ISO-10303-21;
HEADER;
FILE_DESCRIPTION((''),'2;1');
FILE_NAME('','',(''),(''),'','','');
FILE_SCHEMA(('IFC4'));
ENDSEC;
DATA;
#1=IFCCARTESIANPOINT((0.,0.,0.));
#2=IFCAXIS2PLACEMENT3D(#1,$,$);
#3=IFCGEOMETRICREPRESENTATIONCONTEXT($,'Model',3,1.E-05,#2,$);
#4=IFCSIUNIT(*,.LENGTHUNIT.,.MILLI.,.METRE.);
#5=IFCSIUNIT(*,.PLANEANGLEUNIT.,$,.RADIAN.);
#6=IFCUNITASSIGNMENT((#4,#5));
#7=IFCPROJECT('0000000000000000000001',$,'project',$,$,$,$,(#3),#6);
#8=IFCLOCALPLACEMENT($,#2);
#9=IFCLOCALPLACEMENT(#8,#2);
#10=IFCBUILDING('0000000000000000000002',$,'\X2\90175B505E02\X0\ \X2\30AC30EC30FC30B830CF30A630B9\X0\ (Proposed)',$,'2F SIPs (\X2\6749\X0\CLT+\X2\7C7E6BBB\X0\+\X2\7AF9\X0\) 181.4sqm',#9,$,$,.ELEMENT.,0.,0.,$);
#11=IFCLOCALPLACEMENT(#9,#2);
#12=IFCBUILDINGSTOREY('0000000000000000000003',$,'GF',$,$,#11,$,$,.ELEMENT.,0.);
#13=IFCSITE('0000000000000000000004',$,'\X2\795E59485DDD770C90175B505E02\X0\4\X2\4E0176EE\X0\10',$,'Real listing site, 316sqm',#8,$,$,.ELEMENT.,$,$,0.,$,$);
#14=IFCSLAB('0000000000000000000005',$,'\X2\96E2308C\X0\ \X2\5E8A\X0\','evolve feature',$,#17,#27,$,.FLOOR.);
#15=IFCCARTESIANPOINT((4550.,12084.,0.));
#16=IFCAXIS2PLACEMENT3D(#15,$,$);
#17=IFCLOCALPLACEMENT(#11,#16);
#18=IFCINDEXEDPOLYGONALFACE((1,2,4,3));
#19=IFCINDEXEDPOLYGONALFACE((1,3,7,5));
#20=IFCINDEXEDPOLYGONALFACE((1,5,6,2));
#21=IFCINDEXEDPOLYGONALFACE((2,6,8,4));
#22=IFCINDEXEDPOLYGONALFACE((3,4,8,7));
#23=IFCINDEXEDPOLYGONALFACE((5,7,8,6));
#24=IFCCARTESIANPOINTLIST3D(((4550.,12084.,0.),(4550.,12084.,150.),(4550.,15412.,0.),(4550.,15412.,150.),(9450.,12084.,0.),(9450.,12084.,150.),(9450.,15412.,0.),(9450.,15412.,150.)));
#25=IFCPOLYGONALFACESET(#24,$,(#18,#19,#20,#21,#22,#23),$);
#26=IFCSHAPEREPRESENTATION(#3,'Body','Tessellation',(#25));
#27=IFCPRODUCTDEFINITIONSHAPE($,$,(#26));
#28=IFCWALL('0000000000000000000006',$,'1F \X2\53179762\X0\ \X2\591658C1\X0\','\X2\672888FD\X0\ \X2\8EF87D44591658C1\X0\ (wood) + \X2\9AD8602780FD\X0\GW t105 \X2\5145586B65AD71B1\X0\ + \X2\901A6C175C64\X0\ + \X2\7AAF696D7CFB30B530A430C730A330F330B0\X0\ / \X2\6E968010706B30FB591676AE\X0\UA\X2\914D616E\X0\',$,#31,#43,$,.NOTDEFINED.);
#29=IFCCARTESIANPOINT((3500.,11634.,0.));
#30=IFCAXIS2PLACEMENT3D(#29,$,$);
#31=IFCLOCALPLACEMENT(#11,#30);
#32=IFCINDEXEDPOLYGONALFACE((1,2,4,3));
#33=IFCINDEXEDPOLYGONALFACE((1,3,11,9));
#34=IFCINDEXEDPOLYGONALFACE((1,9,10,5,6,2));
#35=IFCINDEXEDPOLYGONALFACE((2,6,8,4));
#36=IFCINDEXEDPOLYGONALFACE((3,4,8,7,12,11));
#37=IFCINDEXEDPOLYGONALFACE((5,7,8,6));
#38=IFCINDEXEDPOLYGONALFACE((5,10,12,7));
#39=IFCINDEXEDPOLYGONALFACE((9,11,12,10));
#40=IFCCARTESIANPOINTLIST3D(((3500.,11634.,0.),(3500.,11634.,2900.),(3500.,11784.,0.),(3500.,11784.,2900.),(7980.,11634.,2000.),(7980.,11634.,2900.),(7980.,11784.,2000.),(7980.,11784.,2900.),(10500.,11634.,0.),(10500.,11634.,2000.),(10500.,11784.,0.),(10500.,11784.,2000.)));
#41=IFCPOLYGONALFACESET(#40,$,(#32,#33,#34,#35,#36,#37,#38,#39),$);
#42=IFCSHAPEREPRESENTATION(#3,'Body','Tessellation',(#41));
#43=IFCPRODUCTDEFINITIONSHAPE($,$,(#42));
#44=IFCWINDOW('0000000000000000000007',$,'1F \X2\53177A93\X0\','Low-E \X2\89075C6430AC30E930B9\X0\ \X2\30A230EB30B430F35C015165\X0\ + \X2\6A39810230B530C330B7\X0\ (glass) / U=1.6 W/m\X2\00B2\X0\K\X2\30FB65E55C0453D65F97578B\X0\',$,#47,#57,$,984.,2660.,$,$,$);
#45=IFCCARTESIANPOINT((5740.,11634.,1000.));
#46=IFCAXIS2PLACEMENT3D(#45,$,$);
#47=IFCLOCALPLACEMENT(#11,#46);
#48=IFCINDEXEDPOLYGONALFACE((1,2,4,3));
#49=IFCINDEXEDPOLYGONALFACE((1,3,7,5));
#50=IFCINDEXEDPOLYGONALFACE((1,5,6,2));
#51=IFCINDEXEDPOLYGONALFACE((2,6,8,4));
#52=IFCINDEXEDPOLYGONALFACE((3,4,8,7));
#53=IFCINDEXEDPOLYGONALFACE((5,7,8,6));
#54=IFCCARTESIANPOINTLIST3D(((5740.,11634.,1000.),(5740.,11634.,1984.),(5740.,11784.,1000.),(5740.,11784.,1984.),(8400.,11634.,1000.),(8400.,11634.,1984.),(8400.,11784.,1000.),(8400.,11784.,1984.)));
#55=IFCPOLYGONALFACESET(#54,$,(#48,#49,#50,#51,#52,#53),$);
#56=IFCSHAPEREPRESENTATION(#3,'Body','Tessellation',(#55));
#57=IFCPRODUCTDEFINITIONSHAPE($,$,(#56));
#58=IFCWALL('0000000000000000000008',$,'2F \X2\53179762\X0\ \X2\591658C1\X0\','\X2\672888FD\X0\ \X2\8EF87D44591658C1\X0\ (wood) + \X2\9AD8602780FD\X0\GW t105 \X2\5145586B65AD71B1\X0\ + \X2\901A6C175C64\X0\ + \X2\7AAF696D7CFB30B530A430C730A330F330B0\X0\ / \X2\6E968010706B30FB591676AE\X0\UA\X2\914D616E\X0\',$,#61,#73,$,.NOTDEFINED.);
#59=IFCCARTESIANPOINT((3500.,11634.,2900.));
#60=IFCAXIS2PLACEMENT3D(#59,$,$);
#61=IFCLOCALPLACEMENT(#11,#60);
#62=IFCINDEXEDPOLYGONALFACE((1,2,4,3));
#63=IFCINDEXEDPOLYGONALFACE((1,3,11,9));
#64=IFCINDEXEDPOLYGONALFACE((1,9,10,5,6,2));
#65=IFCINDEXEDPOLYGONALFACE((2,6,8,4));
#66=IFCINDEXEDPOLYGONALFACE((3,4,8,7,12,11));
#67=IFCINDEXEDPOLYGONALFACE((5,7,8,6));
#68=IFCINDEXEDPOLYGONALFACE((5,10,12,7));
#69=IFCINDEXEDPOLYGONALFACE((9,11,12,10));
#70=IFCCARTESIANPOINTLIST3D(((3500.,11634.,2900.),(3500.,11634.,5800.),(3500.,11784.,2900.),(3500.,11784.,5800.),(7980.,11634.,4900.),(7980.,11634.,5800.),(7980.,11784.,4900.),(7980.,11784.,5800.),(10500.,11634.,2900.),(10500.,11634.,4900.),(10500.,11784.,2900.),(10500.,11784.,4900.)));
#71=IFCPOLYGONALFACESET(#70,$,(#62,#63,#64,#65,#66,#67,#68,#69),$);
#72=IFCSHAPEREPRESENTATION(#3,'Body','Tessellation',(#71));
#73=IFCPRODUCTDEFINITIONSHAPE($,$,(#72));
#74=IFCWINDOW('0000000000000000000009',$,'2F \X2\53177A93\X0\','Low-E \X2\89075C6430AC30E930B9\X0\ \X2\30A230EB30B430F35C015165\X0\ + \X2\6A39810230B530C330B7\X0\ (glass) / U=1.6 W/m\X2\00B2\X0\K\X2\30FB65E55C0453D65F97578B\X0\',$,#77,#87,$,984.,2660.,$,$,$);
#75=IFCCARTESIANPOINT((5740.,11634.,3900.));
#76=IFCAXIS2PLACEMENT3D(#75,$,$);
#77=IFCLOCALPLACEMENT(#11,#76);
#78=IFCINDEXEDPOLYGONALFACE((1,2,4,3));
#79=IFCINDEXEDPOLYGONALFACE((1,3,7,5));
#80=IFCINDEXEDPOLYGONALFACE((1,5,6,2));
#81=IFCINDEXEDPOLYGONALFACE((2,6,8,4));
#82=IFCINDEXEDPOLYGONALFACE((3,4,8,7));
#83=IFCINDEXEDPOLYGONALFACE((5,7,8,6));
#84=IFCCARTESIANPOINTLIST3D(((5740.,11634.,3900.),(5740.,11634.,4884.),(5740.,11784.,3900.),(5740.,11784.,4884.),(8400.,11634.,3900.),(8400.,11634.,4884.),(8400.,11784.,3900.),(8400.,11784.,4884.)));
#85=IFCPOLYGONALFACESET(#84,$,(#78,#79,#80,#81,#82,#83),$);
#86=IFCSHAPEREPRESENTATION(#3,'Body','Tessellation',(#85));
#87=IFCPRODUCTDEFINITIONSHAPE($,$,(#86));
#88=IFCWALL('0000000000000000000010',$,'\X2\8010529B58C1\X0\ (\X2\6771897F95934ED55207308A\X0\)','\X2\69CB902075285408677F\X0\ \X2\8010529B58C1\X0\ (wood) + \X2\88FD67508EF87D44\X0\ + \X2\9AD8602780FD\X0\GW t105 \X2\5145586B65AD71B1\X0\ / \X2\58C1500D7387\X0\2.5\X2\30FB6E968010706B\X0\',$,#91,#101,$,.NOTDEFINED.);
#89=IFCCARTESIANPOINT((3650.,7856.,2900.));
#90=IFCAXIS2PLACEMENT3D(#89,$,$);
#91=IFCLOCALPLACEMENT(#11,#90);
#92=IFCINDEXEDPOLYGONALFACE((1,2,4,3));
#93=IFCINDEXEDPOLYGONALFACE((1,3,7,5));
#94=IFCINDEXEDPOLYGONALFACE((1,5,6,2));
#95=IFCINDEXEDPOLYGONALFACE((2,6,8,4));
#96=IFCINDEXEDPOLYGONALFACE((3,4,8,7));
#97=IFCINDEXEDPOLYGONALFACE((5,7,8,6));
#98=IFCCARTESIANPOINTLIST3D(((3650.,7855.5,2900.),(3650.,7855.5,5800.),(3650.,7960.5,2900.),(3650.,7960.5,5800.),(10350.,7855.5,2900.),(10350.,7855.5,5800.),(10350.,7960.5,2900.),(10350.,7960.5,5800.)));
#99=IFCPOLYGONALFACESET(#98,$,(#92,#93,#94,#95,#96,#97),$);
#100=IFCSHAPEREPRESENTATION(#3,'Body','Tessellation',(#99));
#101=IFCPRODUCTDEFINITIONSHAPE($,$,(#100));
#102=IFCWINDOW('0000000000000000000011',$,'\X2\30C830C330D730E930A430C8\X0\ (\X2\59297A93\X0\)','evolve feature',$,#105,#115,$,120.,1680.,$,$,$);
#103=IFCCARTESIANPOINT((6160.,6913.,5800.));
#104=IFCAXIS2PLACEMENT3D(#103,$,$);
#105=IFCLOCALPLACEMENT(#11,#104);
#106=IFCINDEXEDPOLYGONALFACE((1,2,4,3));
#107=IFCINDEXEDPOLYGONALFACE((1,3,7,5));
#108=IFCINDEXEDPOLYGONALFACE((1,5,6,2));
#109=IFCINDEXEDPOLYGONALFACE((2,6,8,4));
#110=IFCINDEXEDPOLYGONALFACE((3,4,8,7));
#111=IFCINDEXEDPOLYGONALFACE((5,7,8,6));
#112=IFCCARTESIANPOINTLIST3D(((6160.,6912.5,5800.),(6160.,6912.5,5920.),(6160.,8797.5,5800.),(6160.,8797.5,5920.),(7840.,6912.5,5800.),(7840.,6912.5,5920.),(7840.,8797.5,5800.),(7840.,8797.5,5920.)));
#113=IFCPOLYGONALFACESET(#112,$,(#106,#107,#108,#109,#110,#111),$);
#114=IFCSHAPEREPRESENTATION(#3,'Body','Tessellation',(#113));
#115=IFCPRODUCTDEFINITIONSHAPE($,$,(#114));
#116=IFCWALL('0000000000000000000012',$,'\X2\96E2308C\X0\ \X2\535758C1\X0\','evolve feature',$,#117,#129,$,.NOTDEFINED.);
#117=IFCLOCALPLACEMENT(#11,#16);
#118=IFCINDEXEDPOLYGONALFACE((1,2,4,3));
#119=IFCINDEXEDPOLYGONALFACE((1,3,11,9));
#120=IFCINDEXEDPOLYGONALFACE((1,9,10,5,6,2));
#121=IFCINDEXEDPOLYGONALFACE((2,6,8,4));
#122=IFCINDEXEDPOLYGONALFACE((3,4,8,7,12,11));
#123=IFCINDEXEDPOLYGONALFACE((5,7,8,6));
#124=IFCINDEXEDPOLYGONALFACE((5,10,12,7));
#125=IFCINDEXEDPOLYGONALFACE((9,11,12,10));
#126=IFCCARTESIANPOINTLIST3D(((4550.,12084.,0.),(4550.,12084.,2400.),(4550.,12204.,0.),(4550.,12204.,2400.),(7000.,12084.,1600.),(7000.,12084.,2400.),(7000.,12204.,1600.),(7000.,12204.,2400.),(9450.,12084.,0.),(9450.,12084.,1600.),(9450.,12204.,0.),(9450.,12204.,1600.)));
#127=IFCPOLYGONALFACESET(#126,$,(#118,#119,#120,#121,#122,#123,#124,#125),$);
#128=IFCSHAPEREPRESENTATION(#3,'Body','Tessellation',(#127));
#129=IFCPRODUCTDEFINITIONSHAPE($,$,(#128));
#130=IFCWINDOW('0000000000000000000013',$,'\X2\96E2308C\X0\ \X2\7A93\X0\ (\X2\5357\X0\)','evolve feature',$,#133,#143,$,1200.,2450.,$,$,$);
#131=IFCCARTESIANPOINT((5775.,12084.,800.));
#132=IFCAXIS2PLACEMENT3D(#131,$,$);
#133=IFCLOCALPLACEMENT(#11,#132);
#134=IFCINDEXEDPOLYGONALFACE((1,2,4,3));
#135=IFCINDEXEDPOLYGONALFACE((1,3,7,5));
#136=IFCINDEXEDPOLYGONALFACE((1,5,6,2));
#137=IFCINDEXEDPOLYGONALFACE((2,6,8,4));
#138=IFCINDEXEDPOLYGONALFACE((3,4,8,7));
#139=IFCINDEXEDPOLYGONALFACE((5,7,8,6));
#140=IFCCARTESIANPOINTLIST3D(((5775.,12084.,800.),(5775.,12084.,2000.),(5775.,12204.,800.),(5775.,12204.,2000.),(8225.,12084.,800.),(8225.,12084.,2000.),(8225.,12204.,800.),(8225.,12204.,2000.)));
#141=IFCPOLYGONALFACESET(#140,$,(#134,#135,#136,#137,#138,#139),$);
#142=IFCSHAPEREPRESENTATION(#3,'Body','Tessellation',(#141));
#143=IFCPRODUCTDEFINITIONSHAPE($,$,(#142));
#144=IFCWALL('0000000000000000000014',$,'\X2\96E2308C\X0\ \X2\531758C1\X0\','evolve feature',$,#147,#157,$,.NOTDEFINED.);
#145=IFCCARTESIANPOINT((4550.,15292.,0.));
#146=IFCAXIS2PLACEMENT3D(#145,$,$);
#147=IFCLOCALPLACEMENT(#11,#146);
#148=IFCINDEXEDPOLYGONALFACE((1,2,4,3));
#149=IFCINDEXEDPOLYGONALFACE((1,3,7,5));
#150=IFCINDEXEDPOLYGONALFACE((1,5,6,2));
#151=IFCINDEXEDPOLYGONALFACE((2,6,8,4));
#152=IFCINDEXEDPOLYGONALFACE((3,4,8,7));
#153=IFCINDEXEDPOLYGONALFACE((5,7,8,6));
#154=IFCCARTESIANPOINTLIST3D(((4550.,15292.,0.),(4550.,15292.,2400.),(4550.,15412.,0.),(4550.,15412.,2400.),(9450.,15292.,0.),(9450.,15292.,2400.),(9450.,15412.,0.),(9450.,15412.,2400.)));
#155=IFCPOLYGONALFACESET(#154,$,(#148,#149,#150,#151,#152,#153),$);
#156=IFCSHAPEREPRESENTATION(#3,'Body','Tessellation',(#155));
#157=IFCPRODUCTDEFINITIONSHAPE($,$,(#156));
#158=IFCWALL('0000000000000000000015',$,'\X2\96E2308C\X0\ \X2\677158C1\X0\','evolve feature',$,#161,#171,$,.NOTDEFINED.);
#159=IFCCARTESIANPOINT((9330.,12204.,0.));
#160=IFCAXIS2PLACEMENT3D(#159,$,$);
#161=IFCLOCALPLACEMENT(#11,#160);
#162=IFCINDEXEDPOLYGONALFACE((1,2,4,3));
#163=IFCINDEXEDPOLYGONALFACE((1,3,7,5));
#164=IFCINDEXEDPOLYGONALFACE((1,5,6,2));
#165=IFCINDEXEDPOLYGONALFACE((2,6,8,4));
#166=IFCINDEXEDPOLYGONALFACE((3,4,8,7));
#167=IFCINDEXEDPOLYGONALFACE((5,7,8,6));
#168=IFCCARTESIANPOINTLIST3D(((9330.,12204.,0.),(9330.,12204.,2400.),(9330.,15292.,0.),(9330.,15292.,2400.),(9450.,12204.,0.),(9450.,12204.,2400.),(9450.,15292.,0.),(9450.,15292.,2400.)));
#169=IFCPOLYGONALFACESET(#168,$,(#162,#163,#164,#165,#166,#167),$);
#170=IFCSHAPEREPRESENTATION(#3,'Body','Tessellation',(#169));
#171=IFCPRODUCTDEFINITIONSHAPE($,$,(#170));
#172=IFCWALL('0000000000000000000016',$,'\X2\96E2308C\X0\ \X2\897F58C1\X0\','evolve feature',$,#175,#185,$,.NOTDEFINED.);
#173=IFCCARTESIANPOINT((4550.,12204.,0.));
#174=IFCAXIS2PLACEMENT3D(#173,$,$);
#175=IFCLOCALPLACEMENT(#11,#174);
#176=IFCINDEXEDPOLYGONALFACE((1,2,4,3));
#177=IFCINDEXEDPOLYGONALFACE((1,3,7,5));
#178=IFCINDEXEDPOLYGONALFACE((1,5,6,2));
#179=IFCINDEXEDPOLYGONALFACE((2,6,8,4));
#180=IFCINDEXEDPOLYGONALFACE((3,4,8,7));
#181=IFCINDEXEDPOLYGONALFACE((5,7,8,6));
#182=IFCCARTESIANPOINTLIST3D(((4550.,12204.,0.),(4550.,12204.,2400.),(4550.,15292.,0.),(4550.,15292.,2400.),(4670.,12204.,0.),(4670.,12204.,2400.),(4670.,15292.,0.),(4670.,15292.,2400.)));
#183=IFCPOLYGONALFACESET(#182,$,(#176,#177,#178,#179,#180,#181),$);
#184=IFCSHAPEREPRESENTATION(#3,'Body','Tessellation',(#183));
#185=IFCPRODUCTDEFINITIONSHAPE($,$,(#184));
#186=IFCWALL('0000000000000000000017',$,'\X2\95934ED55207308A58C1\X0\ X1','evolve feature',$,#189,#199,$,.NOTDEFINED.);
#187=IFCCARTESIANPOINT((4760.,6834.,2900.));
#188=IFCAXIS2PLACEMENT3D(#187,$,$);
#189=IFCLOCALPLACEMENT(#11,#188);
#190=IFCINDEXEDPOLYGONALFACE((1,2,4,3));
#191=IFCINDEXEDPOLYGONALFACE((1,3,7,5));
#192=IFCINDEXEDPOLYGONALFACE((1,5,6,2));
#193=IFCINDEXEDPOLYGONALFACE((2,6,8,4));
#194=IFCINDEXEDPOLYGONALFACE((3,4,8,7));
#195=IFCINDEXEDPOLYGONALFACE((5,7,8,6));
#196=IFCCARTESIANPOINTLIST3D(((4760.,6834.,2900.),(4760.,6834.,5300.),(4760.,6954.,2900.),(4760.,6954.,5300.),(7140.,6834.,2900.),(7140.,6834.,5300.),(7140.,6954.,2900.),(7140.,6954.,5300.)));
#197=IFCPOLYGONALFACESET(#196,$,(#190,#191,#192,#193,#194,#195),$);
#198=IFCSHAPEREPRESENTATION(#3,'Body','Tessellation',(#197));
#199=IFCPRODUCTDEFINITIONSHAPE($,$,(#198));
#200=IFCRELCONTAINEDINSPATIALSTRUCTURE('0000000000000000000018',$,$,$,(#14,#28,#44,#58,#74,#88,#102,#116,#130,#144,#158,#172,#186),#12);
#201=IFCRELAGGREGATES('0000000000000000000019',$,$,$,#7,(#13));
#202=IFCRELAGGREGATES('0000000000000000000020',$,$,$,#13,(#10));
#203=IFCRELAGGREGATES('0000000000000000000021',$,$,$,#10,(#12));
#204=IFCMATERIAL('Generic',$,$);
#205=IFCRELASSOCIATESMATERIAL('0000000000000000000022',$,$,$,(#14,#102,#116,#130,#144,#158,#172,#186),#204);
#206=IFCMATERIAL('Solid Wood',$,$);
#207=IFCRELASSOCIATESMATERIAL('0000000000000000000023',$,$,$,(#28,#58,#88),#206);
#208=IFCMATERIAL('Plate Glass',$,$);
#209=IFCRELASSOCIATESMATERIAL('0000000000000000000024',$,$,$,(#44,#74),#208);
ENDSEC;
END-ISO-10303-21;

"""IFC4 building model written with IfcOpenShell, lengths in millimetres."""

from ifc_helpers import new_model, si_unit, frame, frame_2d, origin, place, context, project, spatial, rectangle, extrude, material, element, fill, save


model = new_model("IFC4")

# Units and contexts
model_context = context("Model", 3, precision=1e-05, world=origin())
ifc_project = project(units=[si_unit("LENGTHUNIT", "METRE", prefix="MILLI"), si_unit("PLANEANGLEUNIT", "RADIAN")], contexts=[model_context])

# Site, building, storey
site_placement = place(None, origin())
site = spatial("IfcSite", under=ifc_project, at=site_placement, Name="神奈川県逗子市4丁目10", ObjectType="Real listing site, 316sqm", CompositionType="ELEMENT", RefElevation=0.0)
building_placement = place(site_placement, origin())
building = spatial("IfcBuilding", under=site, at=building_placement, Name="逗子市 ガレージハウス (Proposed)", ObjectType="2F SIPs (杉CLT+籾殻+竹) 181.4sqm", CompositionType="ELEMENT", ElevationOfRefHeight=0.0, ElevationOfTerrain=0.0)
storey_placement = place(building_placement, origin())
storey = spatial("IfcBuildingStorey", under=building, at=storey_placement, Name="GF", CompositionType="ELEMENT", Elevation=0.0)

# Slab
ifc_material_1 = material(Name="Generic")
slab_placement = place(storey_placement, frame((4550.0, 12084.0, 0.0)))
element("IfcSlab", 1, at=slab_placement, inside=storey, material=ifc_material_1, Name="離れ 床", Description="evolve feature", PredefinedType="FLOOR", context=model_context, shape_type="SweptSolid", body=[
    extrude(rectangle(XDim=4900.0, YDim=3328.0, at=frame_2d((2450.0, 1664.0))), frame((4550.0, 12084.0, 0.0)), (0.0, 0.0, 1.0), 150.0),
])

# Wall, opening, window
ifc_material_2 = material(Name="Solid Wood")
wall_1_placement = place(storey_placement, frame((3500.0, 11634.0, 0.0)))
wall_1 = element("IfcWall", 2, at=wall_1_placement, inside=storey, material=ifc_material_2, Name="1F 北面 外壁", Description="木製 軸組外壁 (wood) + 高性能GW t105 充填断熱 + 通気層 + 窯業系サイディング / 準耐火・外皮UA配慮", PredefinedType="NOTDEFINED", context=model_context, shape_type="SweptSolid", body=[
    extrude(rectangle(XDim=7000.0, YDim=150.0, at=frame_2d((3500.0, 75.0))), frame((3500.0, 11634.0, 0.0)), (0.0, 0.0, 1.0), 2900.0),
])
opening_1_placement = place(storey_placement, frame((5740.0, 11634.0, 1000.0)))
opening_1 = element("IfcOpeningElement", 3, at=opening_1_placement, cuts=wall_1, PredefinedType="NOTDEFINED", context=model_context, shape_type="SweptSolid", body=[
    extrude(rectangle(XDim=2660.0, YDim=150.0, at=frame_2d((1330.0, 75.0))), frame((5740.0, 11634.0, 1000.0)), (0.0, 0.0, 1.0), 984.0),
])
ifc_material_3 = material(Name="Plate Glass")
window_1_placement = place(storey_placement, frame((5740.0, 11634.0, 1000.0)))
window_1 = element("IfcWindow", 4, at=window_1_placement, inside=storey, material=ifc_material_3, Name="1F 北窓", Description="Low-E 複層ガラス アルゴン封入 + 樹脂サッシ (glass) / U=1.6 W/m²K・日射取得型", OverallHeight=984.0, OverallWidth=2660.0, context=model_context, shape_type="SweptSolid", body=[
    extrude(rectangle(XDim=2660.0, YDim=150.0, at=frame_2d((1330.0, 75.0))), frame((5740.0, 11634.0, 1000.0)), (0.0, 0.0, 1.0), 984.0),
])
fill(opening_1, window_1)

# Wall, opening, window
wall_2_placement = place(storey_placement, frame((3500.0, 11634.0, 2900.0)))
wall_2 = element("IfcWall", 5, at=wall_2_placement, inside=storey, material=ifc_material_2, Name="2F 北面 外壁", Description="木製 軸組外壁 (wood) + 高性能GW t105 充填断熱 + 通気層 + 窯業系サイディング / 準耐火・外皮UA配慮", PredefinedType="NOTDEFINED", context=model_context, shape_type="SweptSolid", body=[
    extrude(rectangle(XDim=7000.0, YDim=150.0, at=frame_2d((3500.0, 75.0))), frame((3500.0, 11634.0, 2900.0)), (0.0, 0.0, 1.0), 2900.0),
])
opening_2_placement = place(storey_placement, frame((5740.0, 11634.0, 3900.0)))
opening_2 = element("IfcOpeningElement", 6, at=opening_2_placement, cuts=wall_2, PredefinedType="NOTDEFINED", context=model_context, shape_type="SweptSolid", body=[
    extrude(rectangle(XDim=2660.0, YDim=150.0, at=frame_2d((1330.0, 75.0))), frame((5740.0, 11634.0, 3900.0)), (0.0, 0.0, 1.0), 984.0),
])
window_2_placement = place(storey_placement, frame((5740.0, 11634.0, 3900.0)))
window_2 = element("IfcWindow", 7, at=window_2_placement, inside=storey, material=ifc_material_3, Name="2F 北窓", Description="Low-E 複層ガラス アルゴン封入 + 樹脂サッシ (glass) / U=1.6 W/m²K・日射取得型", OverallHeight=984.0, OverallWidth=2660.0, context=model_context, shape_type="SweptSolid", body=[
    extrude(rectangle(XDim=2660.0, YDim=150.0, at=frame_2d((1330.0, 75.0))), frame((5740.0, 11634.0, 3900.0)), (0.0, 0.0, 1.0), 984.0),
])
fill(opening_2, window_2)

# Wall
wall_3_placement = place(storey_placement, frame((3650.0, 7856.0, 2900.0)))
element("IfcWall", 8, at=wall_3_placement, inside=storey, material=ifc_material_2, Name="耐力壁 (東西間仕切り)", Description="構造用合板 耐力壁 (wood) + 製材軸組 + 高性能GW t105 充填断熱 / 壁倍率2.5・準耐火", PredefinedType="NOTDEFINED", context=model_context, shape_type="SweptSolid", body=[
    extrude(rectangle(XDim=6700.0, YDim=105.0, at=frame_2d((3350.0, 52.0))), frame((3650.0, 7856.0, 2900.0)), (0.0, 0.0, 1.0), 2900.0),
])

# Window
window_3_placement = place(storey_placement, frame((6160.0, 6913.0, 5800.0)))
element("IfcWindow", 9, at=window_3_placement, inside=storey, material=ifc_material_1, Name="トップライト (天窓)", Description="evolve feature", OverallHeight=120.0, OverallWidth=1680.0, context=model_context, shape_type="SweptSolid", body=[
    extrude(rectangle(XDim=1680.0, YDim=1885.0, at=frame_2d((840.0, 942.0))), frame((6160.0, 6913.0, 5800.0)), (0.0, 0.0, 1.0), 120.0),
])

# Wall, opening, window
wall_4_placement = place(storey_placement, frame((4550.0, 12084.0, 0.0)))
wall_4 = element("IfcWall", 10, at=wall_4_placement, inside=storey, material=ifc_material_1, Name="離れ 南壁", Description="evolve feature", PredefinedType="NOTDEFINED", context=model_context, shape_type="SweptSolid", body=[
    extrude(rectangle(XDim=4900.0, YDim=120.0, at=frame_2d((2450.0, 60.0))), frame((4550.0, 12084.0, 0.0)), (0.0, 0.0, 1.0), 2400.0),
])
opening_3_placement = place(storey_placement, frame((5775.0, 12084.0, 800.0)))
opening_3 = element("IfcOpeningElement", 11, at=opening_3_placement, cuts=wall_4, PredefinedType="NOTDEFINED", context=model_context, shape_type="SweptSolid", body=[
    extrude(rectangle(XDim=2450.0, YDim=120.0, at=frame_2d((1225.0, 60.0))), frame((5775.0, 12084.0, 800.0)), (0.0, 0.0, 1.0), 1200.0),
])
window_4_placement = place(storey_placement, frame((5775.0, 12084.0, 800.0)))
window_4 = element("IfcWindow", 12, at=window_4_placement, inside=storey, material=ifc_material_1, Name="離れ 窓 (南)", Description="evolve feature", OverallHeight=1200.0, OverallWidth=2450.0, context=model_context, shape_type="SweptSolid", body=[
    extrude(rectangle(XDim=2450.0, YDim=120.0, at=frame_2d((1225.0, 60.0))), frame((5775.0, 12084.0, 800.0)), (0.0, 0.0, 1.0), 1200.0),
])
fill(opening_3, window_4)

# Walls
wall_5_placement = place(storey_placement, frame((4550.0, 15292.0, 0.0)))
element("IfcWall", 13, at=wall_5_placement, inside=storey, material=ifc_material_1, Name="離れ 北壁", Description="evolve feature", PredefinedType="NOTDEFINED", context=model_context, shape_type="SweptSolid", body=[
    extrude(rectangle(XDim=4900.0, YDim=120.0, at=frame_2d((2450.0, 60.0))), frame((4550.0, 15292.0, 0.0)), (0.0, 0.0, 1.0), 2400.0),
])
wall_6_placement = place(storey_placement, frame((9330.0, 12204.0, 0.0)))
element("IfcWall", 14, at=wall_6_placement, inside=storey, material=ifc_material_1, Name="離れ 東壁", Description="evolve feature", PredefinedType="NOTDEFINED", context=model_context, shape_type="SweptSolid", body=[
    extrude(rectangle(XDim=120.0, YDim=3088.0, at=frame_2d((60.0, 1544.0))), frame((9330.0, 12204.0, 0.0)), (0.0, 0.0, 1.0), 2400.0),
])
wall_7_placement = place(storey_placement, frame((4550.0, 12204.0, 0.0)))
element("IfcWall", 15, at=wall_7_placement, inside=storey, material=ifc_material_1, Name="離れ 西壁", Description="evolve feature", PredefinedType="NOTDEFINED", context=model_context, shape_type="SweptSolid", body=[
    extrude(rectangle(XDim=120.0, YDim=3088.0, at=frame_2d((60.0, 1544.0))), frame((4550.0, 12204.0, 0.0)), (0.0, 0.0, 1.0), 2400.0),
])
wall_8_placement = place(storey_placement, frame((4760.0, 6834.0, 2900.0)))
element("IfcWall", 16, at=wall_8_placement, inside=storey, material=ifc_material_1, Name="間仕切り壁 X1", Description="evolve feature", PredefinedType="NOTDEFINED", context=model_context, shape_type="SweptSolid", body=[
    extrude(rectangle(XDim=2380.0, YDim=120.0, at=frame_2d((1190.0, 60.0))), frame((4760.0, 6834.0, 2900.0)), (0.0, 0.0, 1.0), 2400.0),
])

save(model, "model.ifc")
